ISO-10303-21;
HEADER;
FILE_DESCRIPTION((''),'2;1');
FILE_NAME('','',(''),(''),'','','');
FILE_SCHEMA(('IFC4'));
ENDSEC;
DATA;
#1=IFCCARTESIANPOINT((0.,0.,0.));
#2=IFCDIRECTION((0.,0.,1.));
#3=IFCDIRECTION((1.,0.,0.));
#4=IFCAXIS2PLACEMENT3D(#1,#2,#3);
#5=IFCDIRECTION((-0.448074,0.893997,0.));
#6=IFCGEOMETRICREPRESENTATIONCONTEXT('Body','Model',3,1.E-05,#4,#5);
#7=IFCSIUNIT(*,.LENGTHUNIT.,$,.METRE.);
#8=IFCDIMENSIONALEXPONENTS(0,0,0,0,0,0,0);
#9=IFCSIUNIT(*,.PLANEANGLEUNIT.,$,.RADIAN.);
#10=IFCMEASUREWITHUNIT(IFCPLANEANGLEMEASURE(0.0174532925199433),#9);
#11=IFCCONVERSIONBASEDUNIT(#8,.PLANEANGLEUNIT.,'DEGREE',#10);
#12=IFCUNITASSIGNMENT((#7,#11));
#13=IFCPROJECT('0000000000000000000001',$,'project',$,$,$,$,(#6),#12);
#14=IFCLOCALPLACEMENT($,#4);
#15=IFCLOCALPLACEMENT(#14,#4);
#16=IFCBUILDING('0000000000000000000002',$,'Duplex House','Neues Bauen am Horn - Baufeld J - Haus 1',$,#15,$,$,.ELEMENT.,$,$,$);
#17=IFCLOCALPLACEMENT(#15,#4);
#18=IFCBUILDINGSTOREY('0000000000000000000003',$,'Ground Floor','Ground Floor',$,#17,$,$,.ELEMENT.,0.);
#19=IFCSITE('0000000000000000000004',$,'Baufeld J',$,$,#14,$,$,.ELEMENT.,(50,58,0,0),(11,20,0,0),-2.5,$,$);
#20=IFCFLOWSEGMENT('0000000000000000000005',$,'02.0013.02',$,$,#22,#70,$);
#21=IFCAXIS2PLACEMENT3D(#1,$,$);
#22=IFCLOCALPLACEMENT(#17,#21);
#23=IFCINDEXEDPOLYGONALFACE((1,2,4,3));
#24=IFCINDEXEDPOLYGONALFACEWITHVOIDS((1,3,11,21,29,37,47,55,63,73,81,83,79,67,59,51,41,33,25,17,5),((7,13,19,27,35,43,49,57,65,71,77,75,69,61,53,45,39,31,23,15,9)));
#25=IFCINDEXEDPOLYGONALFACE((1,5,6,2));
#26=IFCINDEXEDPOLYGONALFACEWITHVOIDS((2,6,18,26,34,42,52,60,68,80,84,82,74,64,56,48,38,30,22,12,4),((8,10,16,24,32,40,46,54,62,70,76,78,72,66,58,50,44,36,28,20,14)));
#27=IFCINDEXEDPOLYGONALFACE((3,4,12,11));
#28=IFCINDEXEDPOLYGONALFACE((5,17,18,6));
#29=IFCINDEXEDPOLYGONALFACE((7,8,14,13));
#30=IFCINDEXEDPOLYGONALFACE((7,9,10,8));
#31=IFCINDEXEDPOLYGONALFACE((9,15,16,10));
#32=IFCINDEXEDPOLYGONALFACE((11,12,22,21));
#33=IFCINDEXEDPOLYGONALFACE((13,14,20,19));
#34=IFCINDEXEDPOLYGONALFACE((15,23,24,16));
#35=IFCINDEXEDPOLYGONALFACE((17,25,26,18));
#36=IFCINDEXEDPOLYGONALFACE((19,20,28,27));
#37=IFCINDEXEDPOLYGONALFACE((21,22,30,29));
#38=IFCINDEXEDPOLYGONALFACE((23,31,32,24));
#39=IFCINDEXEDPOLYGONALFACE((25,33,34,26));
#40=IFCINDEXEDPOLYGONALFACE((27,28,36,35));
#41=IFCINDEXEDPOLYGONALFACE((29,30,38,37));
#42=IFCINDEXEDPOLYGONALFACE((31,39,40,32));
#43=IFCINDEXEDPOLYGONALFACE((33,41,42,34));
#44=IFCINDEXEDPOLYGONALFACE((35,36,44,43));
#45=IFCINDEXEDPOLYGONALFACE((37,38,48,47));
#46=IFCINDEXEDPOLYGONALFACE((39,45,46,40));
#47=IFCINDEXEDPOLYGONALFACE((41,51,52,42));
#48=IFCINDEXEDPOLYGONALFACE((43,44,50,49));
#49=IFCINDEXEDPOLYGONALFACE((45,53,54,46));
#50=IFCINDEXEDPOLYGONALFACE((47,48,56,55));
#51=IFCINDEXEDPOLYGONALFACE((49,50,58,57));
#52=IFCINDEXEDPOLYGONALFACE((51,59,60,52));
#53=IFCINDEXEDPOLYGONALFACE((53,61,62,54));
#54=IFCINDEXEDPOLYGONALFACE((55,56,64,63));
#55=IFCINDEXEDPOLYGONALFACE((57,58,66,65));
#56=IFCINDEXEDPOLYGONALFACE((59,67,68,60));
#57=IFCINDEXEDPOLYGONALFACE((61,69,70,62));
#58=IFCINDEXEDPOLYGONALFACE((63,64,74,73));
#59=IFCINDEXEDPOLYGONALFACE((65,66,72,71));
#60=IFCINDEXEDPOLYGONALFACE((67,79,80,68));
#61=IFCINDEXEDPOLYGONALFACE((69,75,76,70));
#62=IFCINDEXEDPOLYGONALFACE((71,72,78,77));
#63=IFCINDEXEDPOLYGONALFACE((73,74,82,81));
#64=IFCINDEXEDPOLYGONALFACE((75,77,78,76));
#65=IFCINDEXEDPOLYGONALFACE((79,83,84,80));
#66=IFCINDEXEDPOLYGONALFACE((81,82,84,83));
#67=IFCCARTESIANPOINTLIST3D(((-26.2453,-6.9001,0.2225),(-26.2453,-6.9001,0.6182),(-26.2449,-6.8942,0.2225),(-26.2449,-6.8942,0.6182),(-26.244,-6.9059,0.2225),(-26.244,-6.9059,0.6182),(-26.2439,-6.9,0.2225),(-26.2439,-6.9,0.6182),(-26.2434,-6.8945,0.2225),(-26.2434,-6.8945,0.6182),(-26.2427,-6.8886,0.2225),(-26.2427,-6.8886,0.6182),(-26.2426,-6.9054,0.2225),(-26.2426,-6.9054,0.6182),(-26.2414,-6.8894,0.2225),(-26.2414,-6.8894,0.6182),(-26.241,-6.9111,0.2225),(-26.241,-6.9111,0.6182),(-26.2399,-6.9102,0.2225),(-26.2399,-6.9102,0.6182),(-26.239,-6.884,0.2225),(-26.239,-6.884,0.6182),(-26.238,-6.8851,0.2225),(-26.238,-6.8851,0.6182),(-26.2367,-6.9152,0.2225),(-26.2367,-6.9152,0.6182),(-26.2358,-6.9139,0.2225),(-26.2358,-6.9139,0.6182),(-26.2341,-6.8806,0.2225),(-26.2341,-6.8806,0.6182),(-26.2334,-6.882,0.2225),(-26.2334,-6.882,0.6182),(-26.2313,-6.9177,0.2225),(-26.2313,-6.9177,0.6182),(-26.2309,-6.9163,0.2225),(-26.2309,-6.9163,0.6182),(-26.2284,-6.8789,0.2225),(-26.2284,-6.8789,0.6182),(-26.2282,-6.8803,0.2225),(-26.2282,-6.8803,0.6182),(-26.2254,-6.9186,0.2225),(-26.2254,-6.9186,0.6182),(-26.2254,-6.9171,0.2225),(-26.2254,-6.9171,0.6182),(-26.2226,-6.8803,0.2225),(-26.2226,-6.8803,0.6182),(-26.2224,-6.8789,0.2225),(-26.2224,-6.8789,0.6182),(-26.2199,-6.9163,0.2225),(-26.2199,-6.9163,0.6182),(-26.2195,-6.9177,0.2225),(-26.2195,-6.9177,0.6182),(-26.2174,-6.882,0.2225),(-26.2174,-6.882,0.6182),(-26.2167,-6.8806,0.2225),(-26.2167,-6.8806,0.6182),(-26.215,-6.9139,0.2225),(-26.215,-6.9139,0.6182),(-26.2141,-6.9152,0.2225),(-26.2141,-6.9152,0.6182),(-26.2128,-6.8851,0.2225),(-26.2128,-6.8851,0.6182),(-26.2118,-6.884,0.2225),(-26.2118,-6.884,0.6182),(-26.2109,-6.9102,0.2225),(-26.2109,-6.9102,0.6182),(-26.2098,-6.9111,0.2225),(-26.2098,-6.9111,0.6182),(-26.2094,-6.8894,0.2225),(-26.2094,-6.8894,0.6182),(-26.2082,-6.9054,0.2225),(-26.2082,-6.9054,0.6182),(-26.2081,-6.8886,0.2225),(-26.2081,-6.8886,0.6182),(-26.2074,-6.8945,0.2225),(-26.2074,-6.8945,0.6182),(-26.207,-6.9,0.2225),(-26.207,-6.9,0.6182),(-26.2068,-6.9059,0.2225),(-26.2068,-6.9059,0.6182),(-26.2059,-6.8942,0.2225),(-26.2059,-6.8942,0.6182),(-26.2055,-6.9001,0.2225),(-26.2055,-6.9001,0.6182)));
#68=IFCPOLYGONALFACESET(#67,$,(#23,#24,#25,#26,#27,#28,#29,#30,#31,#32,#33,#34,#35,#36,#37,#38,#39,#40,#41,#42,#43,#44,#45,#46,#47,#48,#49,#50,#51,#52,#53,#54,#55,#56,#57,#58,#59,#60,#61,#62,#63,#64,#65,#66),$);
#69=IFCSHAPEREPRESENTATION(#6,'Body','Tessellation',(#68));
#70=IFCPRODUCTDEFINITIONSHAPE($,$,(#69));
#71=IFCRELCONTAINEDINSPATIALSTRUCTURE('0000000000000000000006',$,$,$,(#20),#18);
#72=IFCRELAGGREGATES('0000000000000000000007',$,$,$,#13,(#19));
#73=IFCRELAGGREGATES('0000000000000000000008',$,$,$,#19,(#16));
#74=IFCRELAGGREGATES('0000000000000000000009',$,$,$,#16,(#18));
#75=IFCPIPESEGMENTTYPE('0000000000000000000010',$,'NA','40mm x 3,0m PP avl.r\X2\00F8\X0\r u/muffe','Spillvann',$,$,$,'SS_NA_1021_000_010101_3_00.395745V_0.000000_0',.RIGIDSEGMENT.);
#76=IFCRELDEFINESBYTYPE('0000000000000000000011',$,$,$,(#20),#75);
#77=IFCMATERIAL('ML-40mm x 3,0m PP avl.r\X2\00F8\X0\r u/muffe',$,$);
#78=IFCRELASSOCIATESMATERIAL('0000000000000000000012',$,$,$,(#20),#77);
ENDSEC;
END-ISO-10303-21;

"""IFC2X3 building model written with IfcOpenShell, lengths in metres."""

from ifc_helpers import new_model, entity, si_unit, converted_unit, direction, frame, origin_with_axes, origin_2d_with_axis, place, context, project, spatial, hollow_circle, extrude, material, type_object, element, save


model = new_model("IFC2X3")

# Units and contexts
model_context = context("Model", 3, precision=1e-05, world=origin_with_axes(), true_north=direction((-0.448074, 0.893997, 0.0)), identifier="Body")
ifc_project = project(units=[si_unit("LENGTHUNIT", "METRE"), converted_unit("PLANEANGLEUNIT", "DEGREE", entity("IfcPlaneAngleMeasure", 0.0174532925199433), si_unit("PLANEANGLEUNIT", "RADIAN"), dimensions=[0, 0, 0, 0, 0, 0, 0])], contexts=[model_context])

# Site, building, storey
site_placement = place(None, origin_with_axes())
site = spatial("IfcSite", under=ifc_project, at=site_placement, Name="Baufeld J", CompositionType="ELEMENT", RefLatitude=(50, 58, 0, 0), RefLongitude=(11, 20, 0, 0), RefElevation=-2.5)
building_placement = place(site_placement, origin_with_axes())
building = spatial("IfcBuilding", under=site, at=building_placement, Name="Duplex House", Description="Neues Bauen am Horn - Baufeld J - Haus 1", CompositionType="ELEMENT")
storey_placement = place(building_placement, origin_with_axes())
storey = spatial("IfcBuildingStorey", under=building, at=storey_placement, Name="Ground Floor", Description="Ground Floor", CompositionType="ELEMENT", Elevation=0.0)

# Flow segment
ifc_material_1 = material(Name="ML-40mm x 3,0m PP avl.rør u/muffe")
pipe_segment_type_1 = type_object("IfcPipeSegmentType", Name="NA", Description="40mm x 3,0m PP avl.rør u/muffe", ApplicableOccurrence="Spillvann", ElementType="SS_NA_1021_000_010101_3_00.395745V_0.000000_0", PredefinedType="RIGIDSEGMENT")
flow_segment_1_placement = place(storey_placement, frame((-26.2254, -6.8986, 0.2225), z_axis=(0.0, 1.0, 0.0), x_axis=(0.0, 0.0, 1.0)))
element("IfcFlowSegment", 1, at=flow_segment_1_placement, inside=storey, type_object=pipe_segment_type_1, material=ifc_material_1, Name="02.0013.02", context=model_context, shape_type="SweptSolid", body=[
    extrude(hollow_circle(Radius=0.02, WallThickness=0.0015, at=origin_2d_with_axis()), frame((0.0, 0.0, 0.0), z_axis=(1.0, 0.0, 0.0), x_axis=(0.0, 0.0, -1.0)), (0.0, 0.0, 1.0), 0.3957),
])

save(model, "model.ifc")
